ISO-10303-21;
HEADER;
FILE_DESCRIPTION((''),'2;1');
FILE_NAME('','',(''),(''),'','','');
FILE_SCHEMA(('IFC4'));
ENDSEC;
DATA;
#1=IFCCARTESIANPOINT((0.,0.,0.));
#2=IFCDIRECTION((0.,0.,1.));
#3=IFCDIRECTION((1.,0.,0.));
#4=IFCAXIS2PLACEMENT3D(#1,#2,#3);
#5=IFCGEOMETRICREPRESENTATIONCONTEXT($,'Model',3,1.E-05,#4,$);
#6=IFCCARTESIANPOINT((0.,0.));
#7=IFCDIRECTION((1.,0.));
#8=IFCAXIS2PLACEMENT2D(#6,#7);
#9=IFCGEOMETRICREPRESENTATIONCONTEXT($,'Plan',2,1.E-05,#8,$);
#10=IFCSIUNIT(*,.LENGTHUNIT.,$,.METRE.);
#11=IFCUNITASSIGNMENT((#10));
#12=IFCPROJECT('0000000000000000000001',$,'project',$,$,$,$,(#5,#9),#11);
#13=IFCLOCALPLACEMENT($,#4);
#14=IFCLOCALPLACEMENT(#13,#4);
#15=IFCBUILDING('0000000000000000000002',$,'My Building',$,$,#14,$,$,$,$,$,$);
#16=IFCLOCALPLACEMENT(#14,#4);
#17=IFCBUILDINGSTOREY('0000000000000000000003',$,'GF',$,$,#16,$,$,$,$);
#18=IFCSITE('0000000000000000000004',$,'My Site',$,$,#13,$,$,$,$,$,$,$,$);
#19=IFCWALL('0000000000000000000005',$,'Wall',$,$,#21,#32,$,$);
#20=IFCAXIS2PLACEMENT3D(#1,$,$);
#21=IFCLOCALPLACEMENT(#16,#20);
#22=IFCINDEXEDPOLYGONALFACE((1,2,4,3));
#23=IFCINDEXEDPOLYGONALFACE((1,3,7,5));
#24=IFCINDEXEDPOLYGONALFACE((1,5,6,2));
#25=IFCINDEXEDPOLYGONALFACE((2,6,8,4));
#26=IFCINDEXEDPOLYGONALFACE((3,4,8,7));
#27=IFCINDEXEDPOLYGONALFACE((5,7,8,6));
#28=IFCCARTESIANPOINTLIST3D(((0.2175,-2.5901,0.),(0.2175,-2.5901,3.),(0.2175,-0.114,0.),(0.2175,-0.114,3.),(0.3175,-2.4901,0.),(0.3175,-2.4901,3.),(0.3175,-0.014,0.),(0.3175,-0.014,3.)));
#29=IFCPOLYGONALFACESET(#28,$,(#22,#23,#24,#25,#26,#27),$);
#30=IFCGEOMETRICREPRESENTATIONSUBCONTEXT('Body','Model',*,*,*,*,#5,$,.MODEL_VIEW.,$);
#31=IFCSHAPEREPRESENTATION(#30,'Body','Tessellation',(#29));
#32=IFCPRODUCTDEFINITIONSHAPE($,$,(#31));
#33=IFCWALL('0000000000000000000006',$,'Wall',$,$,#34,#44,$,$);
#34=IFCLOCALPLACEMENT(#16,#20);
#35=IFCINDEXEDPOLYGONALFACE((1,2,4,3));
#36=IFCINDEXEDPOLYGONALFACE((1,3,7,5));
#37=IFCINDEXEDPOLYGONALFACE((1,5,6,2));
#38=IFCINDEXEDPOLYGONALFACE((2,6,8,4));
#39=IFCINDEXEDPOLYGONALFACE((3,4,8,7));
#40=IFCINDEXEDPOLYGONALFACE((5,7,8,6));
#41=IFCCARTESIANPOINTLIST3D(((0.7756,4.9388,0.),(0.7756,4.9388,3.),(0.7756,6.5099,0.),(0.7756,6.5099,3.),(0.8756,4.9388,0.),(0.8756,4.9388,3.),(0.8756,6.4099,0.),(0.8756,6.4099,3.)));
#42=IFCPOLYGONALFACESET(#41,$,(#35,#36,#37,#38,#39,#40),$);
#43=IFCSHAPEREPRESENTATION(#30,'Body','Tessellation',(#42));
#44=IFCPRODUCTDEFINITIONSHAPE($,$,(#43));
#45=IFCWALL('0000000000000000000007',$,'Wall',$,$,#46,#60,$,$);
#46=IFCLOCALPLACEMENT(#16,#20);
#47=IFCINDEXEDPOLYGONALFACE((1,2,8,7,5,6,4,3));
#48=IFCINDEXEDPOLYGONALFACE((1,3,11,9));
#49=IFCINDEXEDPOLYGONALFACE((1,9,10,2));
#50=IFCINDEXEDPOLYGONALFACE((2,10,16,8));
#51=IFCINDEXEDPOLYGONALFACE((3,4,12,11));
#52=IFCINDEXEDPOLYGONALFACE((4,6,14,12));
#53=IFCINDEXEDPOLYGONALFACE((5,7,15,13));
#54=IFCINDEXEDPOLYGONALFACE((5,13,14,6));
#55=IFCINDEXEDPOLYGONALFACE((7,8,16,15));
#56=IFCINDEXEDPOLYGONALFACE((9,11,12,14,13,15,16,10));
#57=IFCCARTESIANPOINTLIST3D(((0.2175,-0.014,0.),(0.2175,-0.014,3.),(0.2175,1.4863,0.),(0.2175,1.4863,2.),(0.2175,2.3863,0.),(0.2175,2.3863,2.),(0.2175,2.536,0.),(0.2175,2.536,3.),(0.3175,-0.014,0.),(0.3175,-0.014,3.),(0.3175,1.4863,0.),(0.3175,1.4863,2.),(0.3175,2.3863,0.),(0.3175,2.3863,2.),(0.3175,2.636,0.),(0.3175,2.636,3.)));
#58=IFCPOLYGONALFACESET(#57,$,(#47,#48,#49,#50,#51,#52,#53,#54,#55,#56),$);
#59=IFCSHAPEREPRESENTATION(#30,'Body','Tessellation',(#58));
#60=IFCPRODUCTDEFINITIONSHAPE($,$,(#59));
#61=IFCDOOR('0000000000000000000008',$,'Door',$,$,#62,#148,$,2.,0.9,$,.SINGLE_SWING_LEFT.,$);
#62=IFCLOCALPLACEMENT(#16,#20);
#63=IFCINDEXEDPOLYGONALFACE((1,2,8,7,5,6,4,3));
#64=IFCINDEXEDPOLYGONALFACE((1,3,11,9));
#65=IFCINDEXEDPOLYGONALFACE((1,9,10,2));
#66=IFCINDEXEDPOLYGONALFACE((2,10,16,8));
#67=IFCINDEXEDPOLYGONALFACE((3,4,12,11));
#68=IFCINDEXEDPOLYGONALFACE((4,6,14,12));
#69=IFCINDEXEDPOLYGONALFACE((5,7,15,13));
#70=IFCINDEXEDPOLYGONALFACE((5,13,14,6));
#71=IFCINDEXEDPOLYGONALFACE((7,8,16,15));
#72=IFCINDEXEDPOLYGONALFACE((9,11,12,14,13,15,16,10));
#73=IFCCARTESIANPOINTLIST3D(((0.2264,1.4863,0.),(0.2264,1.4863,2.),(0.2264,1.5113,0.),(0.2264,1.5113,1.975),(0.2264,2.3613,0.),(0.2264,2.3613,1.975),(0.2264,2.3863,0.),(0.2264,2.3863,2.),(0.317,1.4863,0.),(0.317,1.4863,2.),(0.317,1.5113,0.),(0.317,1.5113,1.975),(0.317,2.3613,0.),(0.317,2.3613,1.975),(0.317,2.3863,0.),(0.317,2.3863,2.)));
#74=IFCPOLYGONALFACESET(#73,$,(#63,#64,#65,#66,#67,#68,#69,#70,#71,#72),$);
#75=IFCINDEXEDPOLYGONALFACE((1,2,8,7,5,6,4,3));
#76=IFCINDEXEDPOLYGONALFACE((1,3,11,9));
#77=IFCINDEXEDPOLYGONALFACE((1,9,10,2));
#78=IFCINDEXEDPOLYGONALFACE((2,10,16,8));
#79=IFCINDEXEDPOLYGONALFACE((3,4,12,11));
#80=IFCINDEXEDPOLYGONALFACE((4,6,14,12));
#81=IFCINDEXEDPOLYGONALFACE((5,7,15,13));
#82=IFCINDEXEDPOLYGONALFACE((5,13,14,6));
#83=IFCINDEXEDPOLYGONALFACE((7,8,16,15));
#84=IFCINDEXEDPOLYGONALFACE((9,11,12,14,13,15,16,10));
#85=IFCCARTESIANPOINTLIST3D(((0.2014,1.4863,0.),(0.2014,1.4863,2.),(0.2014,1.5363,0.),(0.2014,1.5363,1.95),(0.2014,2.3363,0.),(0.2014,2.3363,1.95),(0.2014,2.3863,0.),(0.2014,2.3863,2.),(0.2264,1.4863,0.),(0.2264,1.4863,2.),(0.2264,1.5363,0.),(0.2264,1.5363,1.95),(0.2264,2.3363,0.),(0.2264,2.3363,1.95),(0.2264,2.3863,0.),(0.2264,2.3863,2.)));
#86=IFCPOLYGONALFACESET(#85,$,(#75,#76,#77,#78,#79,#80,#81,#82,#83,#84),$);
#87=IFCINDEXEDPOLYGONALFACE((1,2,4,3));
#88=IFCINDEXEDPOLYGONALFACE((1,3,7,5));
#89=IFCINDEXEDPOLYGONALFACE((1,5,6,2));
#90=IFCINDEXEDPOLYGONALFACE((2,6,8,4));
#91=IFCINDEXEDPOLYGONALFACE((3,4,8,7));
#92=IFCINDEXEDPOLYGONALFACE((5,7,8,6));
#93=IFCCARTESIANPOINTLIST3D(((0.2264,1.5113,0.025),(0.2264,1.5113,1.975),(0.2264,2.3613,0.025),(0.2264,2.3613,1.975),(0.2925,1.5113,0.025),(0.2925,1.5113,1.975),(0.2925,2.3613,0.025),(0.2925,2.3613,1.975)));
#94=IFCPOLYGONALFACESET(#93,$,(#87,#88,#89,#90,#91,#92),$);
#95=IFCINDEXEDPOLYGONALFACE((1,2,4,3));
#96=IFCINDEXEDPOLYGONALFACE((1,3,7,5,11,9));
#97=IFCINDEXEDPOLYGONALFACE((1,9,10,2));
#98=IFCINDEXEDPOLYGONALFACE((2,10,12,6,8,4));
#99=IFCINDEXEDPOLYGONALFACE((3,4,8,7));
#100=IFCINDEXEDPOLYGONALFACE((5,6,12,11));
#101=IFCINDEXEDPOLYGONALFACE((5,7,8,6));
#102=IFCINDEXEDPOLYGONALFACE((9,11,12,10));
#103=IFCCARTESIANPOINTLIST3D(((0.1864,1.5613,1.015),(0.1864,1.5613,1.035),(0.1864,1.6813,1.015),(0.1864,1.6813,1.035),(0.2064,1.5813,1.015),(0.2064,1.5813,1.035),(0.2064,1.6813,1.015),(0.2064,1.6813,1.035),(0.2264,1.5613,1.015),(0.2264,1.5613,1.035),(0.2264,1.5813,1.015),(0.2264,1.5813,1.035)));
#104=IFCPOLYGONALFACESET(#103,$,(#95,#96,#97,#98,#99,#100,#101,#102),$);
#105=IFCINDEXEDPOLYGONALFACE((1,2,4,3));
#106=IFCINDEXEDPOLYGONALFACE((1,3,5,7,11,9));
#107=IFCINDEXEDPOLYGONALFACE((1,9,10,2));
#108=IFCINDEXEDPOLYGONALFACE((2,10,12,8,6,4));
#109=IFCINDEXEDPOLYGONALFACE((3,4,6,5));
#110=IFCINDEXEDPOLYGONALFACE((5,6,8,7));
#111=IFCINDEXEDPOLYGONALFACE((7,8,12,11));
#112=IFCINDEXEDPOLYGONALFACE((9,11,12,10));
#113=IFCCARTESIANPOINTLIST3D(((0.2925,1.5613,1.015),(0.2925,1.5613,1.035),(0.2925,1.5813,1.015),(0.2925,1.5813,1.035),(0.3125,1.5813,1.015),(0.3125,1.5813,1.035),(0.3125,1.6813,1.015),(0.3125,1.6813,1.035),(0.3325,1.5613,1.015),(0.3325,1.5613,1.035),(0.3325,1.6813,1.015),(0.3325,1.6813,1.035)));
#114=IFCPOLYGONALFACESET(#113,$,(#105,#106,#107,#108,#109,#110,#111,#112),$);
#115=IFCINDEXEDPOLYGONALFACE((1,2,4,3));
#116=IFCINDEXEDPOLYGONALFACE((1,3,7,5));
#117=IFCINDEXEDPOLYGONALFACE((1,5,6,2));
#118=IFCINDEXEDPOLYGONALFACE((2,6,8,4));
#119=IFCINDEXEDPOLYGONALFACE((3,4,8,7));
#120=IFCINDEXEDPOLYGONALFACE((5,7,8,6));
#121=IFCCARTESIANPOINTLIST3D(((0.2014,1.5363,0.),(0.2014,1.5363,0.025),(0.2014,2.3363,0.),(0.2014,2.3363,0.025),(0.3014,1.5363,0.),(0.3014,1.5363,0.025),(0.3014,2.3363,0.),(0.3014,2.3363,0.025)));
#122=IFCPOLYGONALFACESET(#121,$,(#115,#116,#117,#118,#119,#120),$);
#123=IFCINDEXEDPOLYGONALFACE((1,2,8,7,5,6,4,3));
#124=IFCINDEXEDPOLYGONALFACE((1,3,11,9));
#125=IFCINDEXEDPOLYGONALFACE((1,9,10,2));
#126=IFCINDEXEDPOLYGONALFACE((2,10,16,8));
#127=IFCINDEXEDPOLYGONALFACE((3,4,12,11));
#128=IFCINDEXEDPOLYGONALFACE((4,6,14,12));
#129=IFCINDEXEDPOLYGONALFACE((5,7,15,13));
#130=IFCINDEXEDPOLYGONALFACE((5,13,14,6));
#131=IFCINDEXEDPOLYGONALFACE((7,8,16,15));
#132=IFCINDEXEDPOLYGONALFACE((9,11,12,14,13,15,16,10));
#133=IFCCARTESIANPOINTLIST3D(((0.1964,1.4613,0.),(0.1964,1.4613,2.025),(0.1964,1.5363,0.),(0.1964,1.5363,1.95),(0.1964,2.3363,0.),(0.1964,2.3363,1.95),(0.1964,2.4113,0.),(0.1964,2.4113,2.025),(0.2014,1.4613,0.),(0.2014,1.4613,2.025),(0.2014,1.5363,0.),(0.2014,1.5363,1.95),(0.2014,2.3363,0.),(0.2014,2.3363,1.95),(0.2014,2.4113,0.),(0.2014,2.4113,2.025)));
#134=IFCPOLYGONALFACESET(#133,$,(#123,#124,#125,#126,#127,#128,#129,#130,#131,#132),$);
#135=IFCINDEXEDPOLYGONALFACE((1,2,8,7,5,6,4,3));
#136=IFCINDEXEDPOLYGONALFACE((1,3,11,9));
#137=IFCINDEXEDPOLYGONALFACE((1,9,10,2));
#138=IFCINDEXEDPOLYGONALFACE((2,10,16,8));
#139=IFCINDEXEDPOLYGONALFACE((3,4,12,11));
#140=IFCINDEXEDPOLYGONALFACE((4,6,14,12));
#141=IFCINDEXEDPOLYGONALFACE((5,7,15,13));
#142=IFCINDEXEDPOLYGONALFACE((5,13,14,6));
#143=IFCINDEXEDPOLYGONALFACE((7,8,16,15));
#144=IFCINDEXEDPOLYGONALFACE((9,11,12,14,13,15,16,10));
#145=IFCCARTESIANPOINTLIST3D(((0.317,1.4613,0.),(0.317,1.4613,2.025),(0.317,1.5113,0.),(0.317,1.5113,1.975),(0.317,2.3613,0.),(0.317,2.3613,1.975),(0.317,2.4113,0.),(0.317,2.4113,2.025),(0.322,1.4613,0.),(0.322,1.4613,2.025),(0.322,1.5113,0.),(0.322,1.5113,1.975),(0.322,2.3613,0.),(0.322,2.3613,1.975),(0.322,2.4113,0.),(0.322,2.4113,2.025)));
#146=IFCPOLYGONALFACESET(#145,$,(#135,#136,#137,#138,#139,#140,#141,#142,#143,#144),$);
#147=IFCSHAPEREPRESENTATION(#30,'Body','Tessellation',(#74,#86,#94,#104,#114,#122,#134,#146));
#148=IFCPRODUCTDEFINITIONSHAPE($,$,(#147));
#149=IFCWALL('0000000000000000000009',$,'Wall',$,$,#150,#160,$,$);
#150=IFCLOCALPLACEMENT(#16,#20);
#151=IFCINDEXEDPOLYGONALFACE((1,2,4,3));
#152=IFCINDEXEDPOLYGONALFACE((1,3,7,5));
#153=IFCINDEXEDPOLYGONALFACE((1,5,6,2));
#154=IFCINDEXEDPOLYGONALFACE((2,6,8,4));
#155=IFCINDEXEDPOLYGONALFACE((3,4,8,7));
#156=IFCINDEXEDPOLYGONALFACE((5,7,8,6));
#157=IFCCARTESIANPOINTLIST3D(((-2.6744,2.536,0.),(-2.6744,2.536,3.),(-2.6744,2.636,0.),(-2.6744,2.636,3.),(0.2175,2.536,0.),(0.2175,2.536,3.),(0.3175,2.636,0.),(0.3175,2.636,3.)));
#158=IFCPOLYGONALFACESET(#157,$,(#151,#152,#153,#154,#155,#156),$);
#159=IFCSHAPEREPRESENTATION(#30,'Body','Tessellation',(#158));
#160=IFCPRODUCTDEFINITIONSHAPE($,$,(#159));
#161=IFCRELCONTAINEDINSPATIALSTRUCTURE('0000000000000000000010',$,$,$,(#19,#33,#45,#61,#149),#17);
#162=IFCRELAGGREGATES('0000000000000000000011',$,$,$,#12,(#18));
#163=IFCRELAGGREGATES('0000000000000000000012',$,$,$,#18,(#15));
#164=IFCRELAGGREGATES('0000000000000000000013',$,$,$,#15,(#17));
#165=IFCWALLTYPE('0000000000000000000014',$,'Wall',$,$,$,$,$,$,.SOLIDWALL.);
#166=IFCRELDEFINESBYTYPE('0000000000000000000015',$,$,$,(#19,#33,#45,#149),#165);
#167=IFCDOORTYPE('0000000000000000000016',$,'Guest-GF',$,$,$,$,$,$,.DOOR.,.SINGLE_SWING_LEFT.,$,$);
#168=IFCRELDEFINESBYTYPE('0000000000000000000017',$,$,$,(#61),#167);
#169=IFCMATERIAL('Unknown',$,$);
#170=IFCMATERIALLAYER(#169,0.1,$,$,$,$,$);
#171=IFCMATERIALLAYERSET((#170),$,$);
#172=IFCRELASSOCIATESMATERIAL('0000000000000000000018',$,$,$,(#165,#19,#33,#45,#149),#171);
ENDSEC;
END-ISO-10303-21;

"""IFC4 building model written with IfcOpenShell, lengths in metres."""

from ifc_helpers import new_model, entity, si_unit, frame, origin_with_axes, origin_2d_with_axis, place, context, subcontext, project, spatial, line, indexed_curve, outline, extrude, shape, source, transform, mapped, material, layer, layer_set, layer_usage, type_object, type_shapes, element, fill, save


model = new_model("IFC4")

# Units and contexts
model_context = context("Model", 3, precision=1e-05, world=origin_with_axes())
plan_context = context("Plan", 2, precision=1e-05, world=origin_2d_with_axis())
body_context_1 = subcontext(model_context, "Body", "Model", "MODEL_VIEW")
body_context_2 = subcontext(plan_context, "Body", "Plan", "PLAN_VIEW")
ifc_project = project(units=[si_unit("LENGTHUNIT", "METRE")], contexts=[model_context, plan_context])

# Site, building, storey
site_placement = place(None, origin_with_axes())
site = spatial("IfcSite", under=ifc_project, at=site_placement, Name="My Site")
building_placement = place(site_placement, origin_with_axes())
building = spatial("IfcBuilding", under=site, at=building_placement, Name="My Building")
storey_placement = place(building_placement, origin_with_axes())
storey = spatial("IfcBuildingStorey", under=building, at=storey_placement, Name="GF")

# Shared definitions
ifc_material = material(Name="Unknown")

# Shared definitions
ifc_layer_1 = layer(ifc_material, 0.1)
ifc_layer_set_1 = layer_set([ifc_layer_1])
wall_type = type_object("IfcWallType", Name="Wall", PredefinedType="SOLIDWALL", material=ifc_layer_set_1)

# Wall
ifc_layer_usage_1 = layer_usage(ifc_layer_set_1, "AXIS2", "POSITIVE", 0.0)
wall_1_placement = place(storey_placement, frame((0.2175, -0.114, 0.0), z_axis=(0.0, 0.0, 1.0), x_axis=(0.0, -1.0, 0.0)))
element("IfcWall", 1, at=wall_1_placement, inside=storey, type_object=wall_type, material=ifc_layer_usage_1, Name="Wall", context=body_context_1, shape_type="SweptSolid", body=[
    extrude(outline(indexed_curve([(0.0, 0.0), (-0.1, 0.1), (2.3761, 0.1), (2.4761, 0.0)], segments=[line(1, 2, 3, 4, 1)])), origin_with_axes(), (0.0, 0.0, 1.0), 3.0),
])

# Wall
ifc_layer_usage_2 = layer_usage(ifc_layer_set_1, "AXIS2", "POSITIVE", 0.0)
wall_2_placement = place(storey_placement, frame((0.7756, 6.5099, 0.0), z_axis=(0.0, 0.0, 1.0), x_axis=(0.0, -1.0, 0.0)))
element("IfcWall", 2, at=wall_2_placement, inside=storey, type_object=wall_type, material=ifc_layer_usage_2, Name="Wall", context=body_context_1, shape_type="SweptSolid", body=[
    extrude(outline(indexed_curve([(0.0, 0.0), (0.1, 0.1), (1.5711, 0.1), (1.5711, 0.0)], segments=[line(1, 2, 3, 4, 1)])), origin_with_axes(), (0.0, 0.0, 1.0), 3.0),
])

# Wall, opening, door
ifc_layer_usage_3 = layer_usage(ifc_layer_set_1, "AXIS2", "POSITIVE", 0.0)
wall_3_placement = place(storey_placement, frame((0.3175, -0.114, 0.0), z_axis=(0.0, 0.0, 1.0), x_axis=(0.0, 1.0, 0.0)))
wall_3 = element("IfcWall", 3, at=wall_3_placement, inside=storey, type_object=wall_type, material=ifc_layer_usage_3, Name="Wall", context=body_context_1, shape_type="SweptSolid", body=[
    extrude(outline(indexed_curve([(0.1, 0.0), (0.1, 0.1), (2.65, 0.1), (2.75, 0.0)], segments=[line(1, 2, 3, 4, 1)])), origin_with_axes(), (0.0, 0.0, 1.0), 3.0),
])
shared_shape_1 = source(origin_with_axes(), body_context_1, "Body", "SweptSolid", [
    extrude(outline(indexed_curve([(0.0, 0.0), (0.9, 0.0), (0.9, 2.0), (0.0, 2.0)], segments=[line(1, 2, 3, 4, 1)])), frame((0.0, -0.6, 0.0), z_axis=(0.0, -1.0, 0.0), x_axis=(1.0, 0.0, 0.0)), (0.0, 0.0, -1.0), 1.2),
])
opening_1_placement = place(wall_3_placement, frame((2.5003, 0.1161, 0.0), z_axis=(0.0, 0.0, 1.0), x_axis=(-1.0, 0.0, 0.0)))
opening_1 = element("IfcOpeningElement", 4, at=opening_1_placement, cuts=wall_3, PredefinedType="OPENING", context=body_context_1, shape_type="MappedRepresentation", body=[
    mapped(shared_shape_1, transform((0.0, 0.0, 0.0), x_axis=(1.0, 0.0, 0.0), y_axis=(0.0, 1.0, 0.0), z_axis=(0.0, 0.0, 1.0), scale=1.0)),
])
door_type_1 = type_object("IfcDoorType", Name="Guest-GF", OperationType="SINGLE_SWING_LEFT", PredefinedType="DOOR")
shared_shape_2 = source(origin_with_axes(), body_context_1, "Body", "SweptSolid", [
    extrude(outline(indexed_curve([(0.0, 0.0), (0.0, 2.0), (0.9, 2.0), (0.9, 0.0), (0.875, 0.0), (0.875, 1.975), (0.025, 1.975), (0.025, 0.0)], segments=[line(1, 2, 3, 4, 5, 6, 7, 8, 1)])), frame((0.0, 0.025, 0.0), z_axis=(0.0, -1.0, 0.0), x_axis=(1.0, 0.0, 0.0)), (0.0, 0.0, -1.0), 0.0906),
    extrude(outline(indexed_curve([(0.0, 0.0), (0.0, 2.0), (0.9, 2.0), (0.9, 0.0), (0.85, 0.0), (0.85, 1.95), (0.05, 1.95), (0.05, 0.0)], segments=[line(1, 2, 3, 4, 5, 6, 7, 8, 1)])), frame((0.0, 0.0, 0.0), z_axis=(0.0, -1.0, 0.0), x_axis=(1.0, 0.0, 0.0)), (0.0, 0.0, -1.0), 0.025),
    extrude(outline(indexed_curve([(0.0, 0.0), (0.85, 0.0), (0.85, 0.0661), (0.0, 0.0661)], segments=[line(1, 2, 3, 4, 1)])), frame((0.025, 0.025, 0.025), z_axis=(0.0, 0.0, 1.0), x_axis=(1.0, 0.0, 0.0)), (0.0, 0.0, 1.0), 1.95),
    extrude(outline(indexed_curve([(0.0, 0.0), (0.0, -0.04), (-0.12, -0.04), (-0.12, -0.02), (-0.02, -0.02), (-0.02, 0.0)], segments=[line(1, 2, 3, 4, 5, 6, 1)])), frame((0.825, 0.025, 1.015), z_axis=(0.0, 0.0, 1.0), x_axis=(1.0, 0.0, 0.0)), (0.0, 0.0, 1.0), 0.02),
    extrude(outline(indexed_curve([(0.0, 0.0), (0.0, 0.04), (-0.12, 0.04), (-0.12, 0.02), (-0.02, 0.02), (-0.02, 0.0)], segments=[line(1, 2, 3, 4, 5, 6, 1)])), frame((0.825, 0.0911, 1.015), z_axis=(0.0, 0.0, 1.0), x_axis=(1.0, 0.0, 0.0)), (0.0, 0.0, 1.0), 0.02),
    extrude(outline(indexed_curve([(0.0, 0.0), (0.8, 0.0), (0.8, 0.1), (0.0, 0.1)], segments=[line(1, 2, 3, 4, 1)])), frame((0.05, 0.0, 0.0), z_axis=(0.0, 0.0, 1.0), x_axis=(1.0, 0.0, 0.0)), (0.0, 0.0, 1.0), 0.025),
    extrude(outline(indexed_curve([(0.0, 0.0), (0.0, 2.025), (0.95, 2.025), (0.95, 0.0), (0.875, 0.0), (0.875, 1.95), (0.075, 1.95), (0.075, 0.0)], segments=[line(1, 2, 3, 4, 5, 6, 7, 8, 1)])), frame((-0.025, -0.005, 0.0), z_axis=(0.0, -1.0, 0.0), x_axis=(1.0, 0.0, 0.0)), (0.0, 0.0, -1.0), 0.005),
    extrude(outline(indexed_curve([(0.0, 0.0), (0.0, 2.025), (0.95, 2.025), (0.95, 0.0), (0.9, 0.0), (0.9, 1.975), (0.05, 1.975), (0.05, 0.0)], segments=[line(1, 2, 3, 4, 5, 6, 7, 8, 1)])), frame((-0.025, 0.1156, 0.0), z_axis=(0.0, -1.0, 0.0), x_axis=(1.0, 0.0, 0.0)), (0.0, 0.0, -1.0), 0.005),
])
shared_shape_3 = source(origin_with_axes(), body_context_2, "Body", "Curve2D", [
    entity("IfcIndexedPolyCurve", entity("IfcCartesianPointList2D", [[0.0, 0.0], [0.0, 0.1156], [0.025, 0.1156], [0.025, 0.025], [0.05, 0.025], [0.05, 0.0]]), [entity("IfcLineIndex", [1, 2, 3, 4, 5, 6, 1])]),
    entity("IfcIndexedPolyCurve", entity("IfcCartesianPointList2D", [[0.9, 0.0], [0.9, 0.1156], [0.875, 0.1156], [0.875, 0.025], [0.85, 0.025], [0.85, 0.0]]), [entity("IfcLineIndex", [1, 2, 3, 4, 5, 6, 1])]),
    entity("IfcTrimmedCurve", entity("IfcEllipse", entity("IfcAxis2Placement2D", entity("IfcCartesianPoint", [0.0911, 0.1156]), entity("IfcDirection", [1.0, 0.0])), 0.7839, 0.85), [entity("IfcCartesianPoint", [0.875, 0.1156])], [entity("IfcCartesianPoint", [0.0911, 0.9656])], True, "CARTESIAN"),
    entity("IfcIndexedPolyCurve", entity("IfcCartesianPointList2D", [[0.025, 0.1156], [0.0911, 0.1156], [0.0911, 0.9656], [0.025, 0.9656]]), [entity("IfcLineIndex", [1, 2, 3, 4, 1])]),
])
type_shapes(door_type_1, [shared_shape_2, shared_shape_3])
door_1_placement = place(opening_1_placement, frame((0.0, 0.0, 0.0), z_axis=(0.0, 0.0, 1.0), x_axis=(1.0, 0.0, 0.0)))
door_1 = element("IfcDoor", 5, at=door_1_placement, inside=storey, type_object=door_type_1, Name="Door", OperationType="SINGLE_SWING_LEFT", OverallHeight=2.0, OverallWidth=0.9, shapes=[
    shape(body_context_1, "Body", "MappedRepresentation", [mapped(shared_shape_2, transform((0.0, 0.0, 0.0), x_axis=(1.0, 0.0, 0.0), y_axis=(0.0, 1.0, 0.0), z_axis=(0.0, 0.0, 1.0), scale=1.0))]),
    shape(body_context_2, "Body", "MappedRepresentation", [mapped(shared_shape_3, transform((0.0, 0.0, 0.0), x_axis=(1.0, 0.0, 0.0), y_axis=(0.0, 1.0, 0.0), z_axis=(0.0, 0.0, 1.0), scale=1.0))]),
])
fill(opening_1, door_1)

# Wall
ifc_layer_usage_4 = layer_usage(ifc_layer_set_1, "AXIS2", "POSITIVE", 0.0)
wall_4_placement = place(storey_placement, frame((0.3175, 2.636, 0.0), z_axis=(0.0, 0.0, 1.0), x_axis=(-1.0, 0.0, 0.0)))
element("IfcWall", 6, at=wall_4_placement, inside=storey, type_object=wall_type, material=ifc_layer_usage_4, Name="Wall", context=body_context_1, shape_type="SweptSolid", body=[
    extrude(outline(indexed_curve([(0.0, 0.0), (0.1, 0.1), (2.9919, 0.1), (2.9919, 0.0)], segments=[line(1, 2, 3, 4, 1)])), origin_with_axes(), (0.0, 0.0, 1.0), 3.0),
])

save(model, "model.ifc")
